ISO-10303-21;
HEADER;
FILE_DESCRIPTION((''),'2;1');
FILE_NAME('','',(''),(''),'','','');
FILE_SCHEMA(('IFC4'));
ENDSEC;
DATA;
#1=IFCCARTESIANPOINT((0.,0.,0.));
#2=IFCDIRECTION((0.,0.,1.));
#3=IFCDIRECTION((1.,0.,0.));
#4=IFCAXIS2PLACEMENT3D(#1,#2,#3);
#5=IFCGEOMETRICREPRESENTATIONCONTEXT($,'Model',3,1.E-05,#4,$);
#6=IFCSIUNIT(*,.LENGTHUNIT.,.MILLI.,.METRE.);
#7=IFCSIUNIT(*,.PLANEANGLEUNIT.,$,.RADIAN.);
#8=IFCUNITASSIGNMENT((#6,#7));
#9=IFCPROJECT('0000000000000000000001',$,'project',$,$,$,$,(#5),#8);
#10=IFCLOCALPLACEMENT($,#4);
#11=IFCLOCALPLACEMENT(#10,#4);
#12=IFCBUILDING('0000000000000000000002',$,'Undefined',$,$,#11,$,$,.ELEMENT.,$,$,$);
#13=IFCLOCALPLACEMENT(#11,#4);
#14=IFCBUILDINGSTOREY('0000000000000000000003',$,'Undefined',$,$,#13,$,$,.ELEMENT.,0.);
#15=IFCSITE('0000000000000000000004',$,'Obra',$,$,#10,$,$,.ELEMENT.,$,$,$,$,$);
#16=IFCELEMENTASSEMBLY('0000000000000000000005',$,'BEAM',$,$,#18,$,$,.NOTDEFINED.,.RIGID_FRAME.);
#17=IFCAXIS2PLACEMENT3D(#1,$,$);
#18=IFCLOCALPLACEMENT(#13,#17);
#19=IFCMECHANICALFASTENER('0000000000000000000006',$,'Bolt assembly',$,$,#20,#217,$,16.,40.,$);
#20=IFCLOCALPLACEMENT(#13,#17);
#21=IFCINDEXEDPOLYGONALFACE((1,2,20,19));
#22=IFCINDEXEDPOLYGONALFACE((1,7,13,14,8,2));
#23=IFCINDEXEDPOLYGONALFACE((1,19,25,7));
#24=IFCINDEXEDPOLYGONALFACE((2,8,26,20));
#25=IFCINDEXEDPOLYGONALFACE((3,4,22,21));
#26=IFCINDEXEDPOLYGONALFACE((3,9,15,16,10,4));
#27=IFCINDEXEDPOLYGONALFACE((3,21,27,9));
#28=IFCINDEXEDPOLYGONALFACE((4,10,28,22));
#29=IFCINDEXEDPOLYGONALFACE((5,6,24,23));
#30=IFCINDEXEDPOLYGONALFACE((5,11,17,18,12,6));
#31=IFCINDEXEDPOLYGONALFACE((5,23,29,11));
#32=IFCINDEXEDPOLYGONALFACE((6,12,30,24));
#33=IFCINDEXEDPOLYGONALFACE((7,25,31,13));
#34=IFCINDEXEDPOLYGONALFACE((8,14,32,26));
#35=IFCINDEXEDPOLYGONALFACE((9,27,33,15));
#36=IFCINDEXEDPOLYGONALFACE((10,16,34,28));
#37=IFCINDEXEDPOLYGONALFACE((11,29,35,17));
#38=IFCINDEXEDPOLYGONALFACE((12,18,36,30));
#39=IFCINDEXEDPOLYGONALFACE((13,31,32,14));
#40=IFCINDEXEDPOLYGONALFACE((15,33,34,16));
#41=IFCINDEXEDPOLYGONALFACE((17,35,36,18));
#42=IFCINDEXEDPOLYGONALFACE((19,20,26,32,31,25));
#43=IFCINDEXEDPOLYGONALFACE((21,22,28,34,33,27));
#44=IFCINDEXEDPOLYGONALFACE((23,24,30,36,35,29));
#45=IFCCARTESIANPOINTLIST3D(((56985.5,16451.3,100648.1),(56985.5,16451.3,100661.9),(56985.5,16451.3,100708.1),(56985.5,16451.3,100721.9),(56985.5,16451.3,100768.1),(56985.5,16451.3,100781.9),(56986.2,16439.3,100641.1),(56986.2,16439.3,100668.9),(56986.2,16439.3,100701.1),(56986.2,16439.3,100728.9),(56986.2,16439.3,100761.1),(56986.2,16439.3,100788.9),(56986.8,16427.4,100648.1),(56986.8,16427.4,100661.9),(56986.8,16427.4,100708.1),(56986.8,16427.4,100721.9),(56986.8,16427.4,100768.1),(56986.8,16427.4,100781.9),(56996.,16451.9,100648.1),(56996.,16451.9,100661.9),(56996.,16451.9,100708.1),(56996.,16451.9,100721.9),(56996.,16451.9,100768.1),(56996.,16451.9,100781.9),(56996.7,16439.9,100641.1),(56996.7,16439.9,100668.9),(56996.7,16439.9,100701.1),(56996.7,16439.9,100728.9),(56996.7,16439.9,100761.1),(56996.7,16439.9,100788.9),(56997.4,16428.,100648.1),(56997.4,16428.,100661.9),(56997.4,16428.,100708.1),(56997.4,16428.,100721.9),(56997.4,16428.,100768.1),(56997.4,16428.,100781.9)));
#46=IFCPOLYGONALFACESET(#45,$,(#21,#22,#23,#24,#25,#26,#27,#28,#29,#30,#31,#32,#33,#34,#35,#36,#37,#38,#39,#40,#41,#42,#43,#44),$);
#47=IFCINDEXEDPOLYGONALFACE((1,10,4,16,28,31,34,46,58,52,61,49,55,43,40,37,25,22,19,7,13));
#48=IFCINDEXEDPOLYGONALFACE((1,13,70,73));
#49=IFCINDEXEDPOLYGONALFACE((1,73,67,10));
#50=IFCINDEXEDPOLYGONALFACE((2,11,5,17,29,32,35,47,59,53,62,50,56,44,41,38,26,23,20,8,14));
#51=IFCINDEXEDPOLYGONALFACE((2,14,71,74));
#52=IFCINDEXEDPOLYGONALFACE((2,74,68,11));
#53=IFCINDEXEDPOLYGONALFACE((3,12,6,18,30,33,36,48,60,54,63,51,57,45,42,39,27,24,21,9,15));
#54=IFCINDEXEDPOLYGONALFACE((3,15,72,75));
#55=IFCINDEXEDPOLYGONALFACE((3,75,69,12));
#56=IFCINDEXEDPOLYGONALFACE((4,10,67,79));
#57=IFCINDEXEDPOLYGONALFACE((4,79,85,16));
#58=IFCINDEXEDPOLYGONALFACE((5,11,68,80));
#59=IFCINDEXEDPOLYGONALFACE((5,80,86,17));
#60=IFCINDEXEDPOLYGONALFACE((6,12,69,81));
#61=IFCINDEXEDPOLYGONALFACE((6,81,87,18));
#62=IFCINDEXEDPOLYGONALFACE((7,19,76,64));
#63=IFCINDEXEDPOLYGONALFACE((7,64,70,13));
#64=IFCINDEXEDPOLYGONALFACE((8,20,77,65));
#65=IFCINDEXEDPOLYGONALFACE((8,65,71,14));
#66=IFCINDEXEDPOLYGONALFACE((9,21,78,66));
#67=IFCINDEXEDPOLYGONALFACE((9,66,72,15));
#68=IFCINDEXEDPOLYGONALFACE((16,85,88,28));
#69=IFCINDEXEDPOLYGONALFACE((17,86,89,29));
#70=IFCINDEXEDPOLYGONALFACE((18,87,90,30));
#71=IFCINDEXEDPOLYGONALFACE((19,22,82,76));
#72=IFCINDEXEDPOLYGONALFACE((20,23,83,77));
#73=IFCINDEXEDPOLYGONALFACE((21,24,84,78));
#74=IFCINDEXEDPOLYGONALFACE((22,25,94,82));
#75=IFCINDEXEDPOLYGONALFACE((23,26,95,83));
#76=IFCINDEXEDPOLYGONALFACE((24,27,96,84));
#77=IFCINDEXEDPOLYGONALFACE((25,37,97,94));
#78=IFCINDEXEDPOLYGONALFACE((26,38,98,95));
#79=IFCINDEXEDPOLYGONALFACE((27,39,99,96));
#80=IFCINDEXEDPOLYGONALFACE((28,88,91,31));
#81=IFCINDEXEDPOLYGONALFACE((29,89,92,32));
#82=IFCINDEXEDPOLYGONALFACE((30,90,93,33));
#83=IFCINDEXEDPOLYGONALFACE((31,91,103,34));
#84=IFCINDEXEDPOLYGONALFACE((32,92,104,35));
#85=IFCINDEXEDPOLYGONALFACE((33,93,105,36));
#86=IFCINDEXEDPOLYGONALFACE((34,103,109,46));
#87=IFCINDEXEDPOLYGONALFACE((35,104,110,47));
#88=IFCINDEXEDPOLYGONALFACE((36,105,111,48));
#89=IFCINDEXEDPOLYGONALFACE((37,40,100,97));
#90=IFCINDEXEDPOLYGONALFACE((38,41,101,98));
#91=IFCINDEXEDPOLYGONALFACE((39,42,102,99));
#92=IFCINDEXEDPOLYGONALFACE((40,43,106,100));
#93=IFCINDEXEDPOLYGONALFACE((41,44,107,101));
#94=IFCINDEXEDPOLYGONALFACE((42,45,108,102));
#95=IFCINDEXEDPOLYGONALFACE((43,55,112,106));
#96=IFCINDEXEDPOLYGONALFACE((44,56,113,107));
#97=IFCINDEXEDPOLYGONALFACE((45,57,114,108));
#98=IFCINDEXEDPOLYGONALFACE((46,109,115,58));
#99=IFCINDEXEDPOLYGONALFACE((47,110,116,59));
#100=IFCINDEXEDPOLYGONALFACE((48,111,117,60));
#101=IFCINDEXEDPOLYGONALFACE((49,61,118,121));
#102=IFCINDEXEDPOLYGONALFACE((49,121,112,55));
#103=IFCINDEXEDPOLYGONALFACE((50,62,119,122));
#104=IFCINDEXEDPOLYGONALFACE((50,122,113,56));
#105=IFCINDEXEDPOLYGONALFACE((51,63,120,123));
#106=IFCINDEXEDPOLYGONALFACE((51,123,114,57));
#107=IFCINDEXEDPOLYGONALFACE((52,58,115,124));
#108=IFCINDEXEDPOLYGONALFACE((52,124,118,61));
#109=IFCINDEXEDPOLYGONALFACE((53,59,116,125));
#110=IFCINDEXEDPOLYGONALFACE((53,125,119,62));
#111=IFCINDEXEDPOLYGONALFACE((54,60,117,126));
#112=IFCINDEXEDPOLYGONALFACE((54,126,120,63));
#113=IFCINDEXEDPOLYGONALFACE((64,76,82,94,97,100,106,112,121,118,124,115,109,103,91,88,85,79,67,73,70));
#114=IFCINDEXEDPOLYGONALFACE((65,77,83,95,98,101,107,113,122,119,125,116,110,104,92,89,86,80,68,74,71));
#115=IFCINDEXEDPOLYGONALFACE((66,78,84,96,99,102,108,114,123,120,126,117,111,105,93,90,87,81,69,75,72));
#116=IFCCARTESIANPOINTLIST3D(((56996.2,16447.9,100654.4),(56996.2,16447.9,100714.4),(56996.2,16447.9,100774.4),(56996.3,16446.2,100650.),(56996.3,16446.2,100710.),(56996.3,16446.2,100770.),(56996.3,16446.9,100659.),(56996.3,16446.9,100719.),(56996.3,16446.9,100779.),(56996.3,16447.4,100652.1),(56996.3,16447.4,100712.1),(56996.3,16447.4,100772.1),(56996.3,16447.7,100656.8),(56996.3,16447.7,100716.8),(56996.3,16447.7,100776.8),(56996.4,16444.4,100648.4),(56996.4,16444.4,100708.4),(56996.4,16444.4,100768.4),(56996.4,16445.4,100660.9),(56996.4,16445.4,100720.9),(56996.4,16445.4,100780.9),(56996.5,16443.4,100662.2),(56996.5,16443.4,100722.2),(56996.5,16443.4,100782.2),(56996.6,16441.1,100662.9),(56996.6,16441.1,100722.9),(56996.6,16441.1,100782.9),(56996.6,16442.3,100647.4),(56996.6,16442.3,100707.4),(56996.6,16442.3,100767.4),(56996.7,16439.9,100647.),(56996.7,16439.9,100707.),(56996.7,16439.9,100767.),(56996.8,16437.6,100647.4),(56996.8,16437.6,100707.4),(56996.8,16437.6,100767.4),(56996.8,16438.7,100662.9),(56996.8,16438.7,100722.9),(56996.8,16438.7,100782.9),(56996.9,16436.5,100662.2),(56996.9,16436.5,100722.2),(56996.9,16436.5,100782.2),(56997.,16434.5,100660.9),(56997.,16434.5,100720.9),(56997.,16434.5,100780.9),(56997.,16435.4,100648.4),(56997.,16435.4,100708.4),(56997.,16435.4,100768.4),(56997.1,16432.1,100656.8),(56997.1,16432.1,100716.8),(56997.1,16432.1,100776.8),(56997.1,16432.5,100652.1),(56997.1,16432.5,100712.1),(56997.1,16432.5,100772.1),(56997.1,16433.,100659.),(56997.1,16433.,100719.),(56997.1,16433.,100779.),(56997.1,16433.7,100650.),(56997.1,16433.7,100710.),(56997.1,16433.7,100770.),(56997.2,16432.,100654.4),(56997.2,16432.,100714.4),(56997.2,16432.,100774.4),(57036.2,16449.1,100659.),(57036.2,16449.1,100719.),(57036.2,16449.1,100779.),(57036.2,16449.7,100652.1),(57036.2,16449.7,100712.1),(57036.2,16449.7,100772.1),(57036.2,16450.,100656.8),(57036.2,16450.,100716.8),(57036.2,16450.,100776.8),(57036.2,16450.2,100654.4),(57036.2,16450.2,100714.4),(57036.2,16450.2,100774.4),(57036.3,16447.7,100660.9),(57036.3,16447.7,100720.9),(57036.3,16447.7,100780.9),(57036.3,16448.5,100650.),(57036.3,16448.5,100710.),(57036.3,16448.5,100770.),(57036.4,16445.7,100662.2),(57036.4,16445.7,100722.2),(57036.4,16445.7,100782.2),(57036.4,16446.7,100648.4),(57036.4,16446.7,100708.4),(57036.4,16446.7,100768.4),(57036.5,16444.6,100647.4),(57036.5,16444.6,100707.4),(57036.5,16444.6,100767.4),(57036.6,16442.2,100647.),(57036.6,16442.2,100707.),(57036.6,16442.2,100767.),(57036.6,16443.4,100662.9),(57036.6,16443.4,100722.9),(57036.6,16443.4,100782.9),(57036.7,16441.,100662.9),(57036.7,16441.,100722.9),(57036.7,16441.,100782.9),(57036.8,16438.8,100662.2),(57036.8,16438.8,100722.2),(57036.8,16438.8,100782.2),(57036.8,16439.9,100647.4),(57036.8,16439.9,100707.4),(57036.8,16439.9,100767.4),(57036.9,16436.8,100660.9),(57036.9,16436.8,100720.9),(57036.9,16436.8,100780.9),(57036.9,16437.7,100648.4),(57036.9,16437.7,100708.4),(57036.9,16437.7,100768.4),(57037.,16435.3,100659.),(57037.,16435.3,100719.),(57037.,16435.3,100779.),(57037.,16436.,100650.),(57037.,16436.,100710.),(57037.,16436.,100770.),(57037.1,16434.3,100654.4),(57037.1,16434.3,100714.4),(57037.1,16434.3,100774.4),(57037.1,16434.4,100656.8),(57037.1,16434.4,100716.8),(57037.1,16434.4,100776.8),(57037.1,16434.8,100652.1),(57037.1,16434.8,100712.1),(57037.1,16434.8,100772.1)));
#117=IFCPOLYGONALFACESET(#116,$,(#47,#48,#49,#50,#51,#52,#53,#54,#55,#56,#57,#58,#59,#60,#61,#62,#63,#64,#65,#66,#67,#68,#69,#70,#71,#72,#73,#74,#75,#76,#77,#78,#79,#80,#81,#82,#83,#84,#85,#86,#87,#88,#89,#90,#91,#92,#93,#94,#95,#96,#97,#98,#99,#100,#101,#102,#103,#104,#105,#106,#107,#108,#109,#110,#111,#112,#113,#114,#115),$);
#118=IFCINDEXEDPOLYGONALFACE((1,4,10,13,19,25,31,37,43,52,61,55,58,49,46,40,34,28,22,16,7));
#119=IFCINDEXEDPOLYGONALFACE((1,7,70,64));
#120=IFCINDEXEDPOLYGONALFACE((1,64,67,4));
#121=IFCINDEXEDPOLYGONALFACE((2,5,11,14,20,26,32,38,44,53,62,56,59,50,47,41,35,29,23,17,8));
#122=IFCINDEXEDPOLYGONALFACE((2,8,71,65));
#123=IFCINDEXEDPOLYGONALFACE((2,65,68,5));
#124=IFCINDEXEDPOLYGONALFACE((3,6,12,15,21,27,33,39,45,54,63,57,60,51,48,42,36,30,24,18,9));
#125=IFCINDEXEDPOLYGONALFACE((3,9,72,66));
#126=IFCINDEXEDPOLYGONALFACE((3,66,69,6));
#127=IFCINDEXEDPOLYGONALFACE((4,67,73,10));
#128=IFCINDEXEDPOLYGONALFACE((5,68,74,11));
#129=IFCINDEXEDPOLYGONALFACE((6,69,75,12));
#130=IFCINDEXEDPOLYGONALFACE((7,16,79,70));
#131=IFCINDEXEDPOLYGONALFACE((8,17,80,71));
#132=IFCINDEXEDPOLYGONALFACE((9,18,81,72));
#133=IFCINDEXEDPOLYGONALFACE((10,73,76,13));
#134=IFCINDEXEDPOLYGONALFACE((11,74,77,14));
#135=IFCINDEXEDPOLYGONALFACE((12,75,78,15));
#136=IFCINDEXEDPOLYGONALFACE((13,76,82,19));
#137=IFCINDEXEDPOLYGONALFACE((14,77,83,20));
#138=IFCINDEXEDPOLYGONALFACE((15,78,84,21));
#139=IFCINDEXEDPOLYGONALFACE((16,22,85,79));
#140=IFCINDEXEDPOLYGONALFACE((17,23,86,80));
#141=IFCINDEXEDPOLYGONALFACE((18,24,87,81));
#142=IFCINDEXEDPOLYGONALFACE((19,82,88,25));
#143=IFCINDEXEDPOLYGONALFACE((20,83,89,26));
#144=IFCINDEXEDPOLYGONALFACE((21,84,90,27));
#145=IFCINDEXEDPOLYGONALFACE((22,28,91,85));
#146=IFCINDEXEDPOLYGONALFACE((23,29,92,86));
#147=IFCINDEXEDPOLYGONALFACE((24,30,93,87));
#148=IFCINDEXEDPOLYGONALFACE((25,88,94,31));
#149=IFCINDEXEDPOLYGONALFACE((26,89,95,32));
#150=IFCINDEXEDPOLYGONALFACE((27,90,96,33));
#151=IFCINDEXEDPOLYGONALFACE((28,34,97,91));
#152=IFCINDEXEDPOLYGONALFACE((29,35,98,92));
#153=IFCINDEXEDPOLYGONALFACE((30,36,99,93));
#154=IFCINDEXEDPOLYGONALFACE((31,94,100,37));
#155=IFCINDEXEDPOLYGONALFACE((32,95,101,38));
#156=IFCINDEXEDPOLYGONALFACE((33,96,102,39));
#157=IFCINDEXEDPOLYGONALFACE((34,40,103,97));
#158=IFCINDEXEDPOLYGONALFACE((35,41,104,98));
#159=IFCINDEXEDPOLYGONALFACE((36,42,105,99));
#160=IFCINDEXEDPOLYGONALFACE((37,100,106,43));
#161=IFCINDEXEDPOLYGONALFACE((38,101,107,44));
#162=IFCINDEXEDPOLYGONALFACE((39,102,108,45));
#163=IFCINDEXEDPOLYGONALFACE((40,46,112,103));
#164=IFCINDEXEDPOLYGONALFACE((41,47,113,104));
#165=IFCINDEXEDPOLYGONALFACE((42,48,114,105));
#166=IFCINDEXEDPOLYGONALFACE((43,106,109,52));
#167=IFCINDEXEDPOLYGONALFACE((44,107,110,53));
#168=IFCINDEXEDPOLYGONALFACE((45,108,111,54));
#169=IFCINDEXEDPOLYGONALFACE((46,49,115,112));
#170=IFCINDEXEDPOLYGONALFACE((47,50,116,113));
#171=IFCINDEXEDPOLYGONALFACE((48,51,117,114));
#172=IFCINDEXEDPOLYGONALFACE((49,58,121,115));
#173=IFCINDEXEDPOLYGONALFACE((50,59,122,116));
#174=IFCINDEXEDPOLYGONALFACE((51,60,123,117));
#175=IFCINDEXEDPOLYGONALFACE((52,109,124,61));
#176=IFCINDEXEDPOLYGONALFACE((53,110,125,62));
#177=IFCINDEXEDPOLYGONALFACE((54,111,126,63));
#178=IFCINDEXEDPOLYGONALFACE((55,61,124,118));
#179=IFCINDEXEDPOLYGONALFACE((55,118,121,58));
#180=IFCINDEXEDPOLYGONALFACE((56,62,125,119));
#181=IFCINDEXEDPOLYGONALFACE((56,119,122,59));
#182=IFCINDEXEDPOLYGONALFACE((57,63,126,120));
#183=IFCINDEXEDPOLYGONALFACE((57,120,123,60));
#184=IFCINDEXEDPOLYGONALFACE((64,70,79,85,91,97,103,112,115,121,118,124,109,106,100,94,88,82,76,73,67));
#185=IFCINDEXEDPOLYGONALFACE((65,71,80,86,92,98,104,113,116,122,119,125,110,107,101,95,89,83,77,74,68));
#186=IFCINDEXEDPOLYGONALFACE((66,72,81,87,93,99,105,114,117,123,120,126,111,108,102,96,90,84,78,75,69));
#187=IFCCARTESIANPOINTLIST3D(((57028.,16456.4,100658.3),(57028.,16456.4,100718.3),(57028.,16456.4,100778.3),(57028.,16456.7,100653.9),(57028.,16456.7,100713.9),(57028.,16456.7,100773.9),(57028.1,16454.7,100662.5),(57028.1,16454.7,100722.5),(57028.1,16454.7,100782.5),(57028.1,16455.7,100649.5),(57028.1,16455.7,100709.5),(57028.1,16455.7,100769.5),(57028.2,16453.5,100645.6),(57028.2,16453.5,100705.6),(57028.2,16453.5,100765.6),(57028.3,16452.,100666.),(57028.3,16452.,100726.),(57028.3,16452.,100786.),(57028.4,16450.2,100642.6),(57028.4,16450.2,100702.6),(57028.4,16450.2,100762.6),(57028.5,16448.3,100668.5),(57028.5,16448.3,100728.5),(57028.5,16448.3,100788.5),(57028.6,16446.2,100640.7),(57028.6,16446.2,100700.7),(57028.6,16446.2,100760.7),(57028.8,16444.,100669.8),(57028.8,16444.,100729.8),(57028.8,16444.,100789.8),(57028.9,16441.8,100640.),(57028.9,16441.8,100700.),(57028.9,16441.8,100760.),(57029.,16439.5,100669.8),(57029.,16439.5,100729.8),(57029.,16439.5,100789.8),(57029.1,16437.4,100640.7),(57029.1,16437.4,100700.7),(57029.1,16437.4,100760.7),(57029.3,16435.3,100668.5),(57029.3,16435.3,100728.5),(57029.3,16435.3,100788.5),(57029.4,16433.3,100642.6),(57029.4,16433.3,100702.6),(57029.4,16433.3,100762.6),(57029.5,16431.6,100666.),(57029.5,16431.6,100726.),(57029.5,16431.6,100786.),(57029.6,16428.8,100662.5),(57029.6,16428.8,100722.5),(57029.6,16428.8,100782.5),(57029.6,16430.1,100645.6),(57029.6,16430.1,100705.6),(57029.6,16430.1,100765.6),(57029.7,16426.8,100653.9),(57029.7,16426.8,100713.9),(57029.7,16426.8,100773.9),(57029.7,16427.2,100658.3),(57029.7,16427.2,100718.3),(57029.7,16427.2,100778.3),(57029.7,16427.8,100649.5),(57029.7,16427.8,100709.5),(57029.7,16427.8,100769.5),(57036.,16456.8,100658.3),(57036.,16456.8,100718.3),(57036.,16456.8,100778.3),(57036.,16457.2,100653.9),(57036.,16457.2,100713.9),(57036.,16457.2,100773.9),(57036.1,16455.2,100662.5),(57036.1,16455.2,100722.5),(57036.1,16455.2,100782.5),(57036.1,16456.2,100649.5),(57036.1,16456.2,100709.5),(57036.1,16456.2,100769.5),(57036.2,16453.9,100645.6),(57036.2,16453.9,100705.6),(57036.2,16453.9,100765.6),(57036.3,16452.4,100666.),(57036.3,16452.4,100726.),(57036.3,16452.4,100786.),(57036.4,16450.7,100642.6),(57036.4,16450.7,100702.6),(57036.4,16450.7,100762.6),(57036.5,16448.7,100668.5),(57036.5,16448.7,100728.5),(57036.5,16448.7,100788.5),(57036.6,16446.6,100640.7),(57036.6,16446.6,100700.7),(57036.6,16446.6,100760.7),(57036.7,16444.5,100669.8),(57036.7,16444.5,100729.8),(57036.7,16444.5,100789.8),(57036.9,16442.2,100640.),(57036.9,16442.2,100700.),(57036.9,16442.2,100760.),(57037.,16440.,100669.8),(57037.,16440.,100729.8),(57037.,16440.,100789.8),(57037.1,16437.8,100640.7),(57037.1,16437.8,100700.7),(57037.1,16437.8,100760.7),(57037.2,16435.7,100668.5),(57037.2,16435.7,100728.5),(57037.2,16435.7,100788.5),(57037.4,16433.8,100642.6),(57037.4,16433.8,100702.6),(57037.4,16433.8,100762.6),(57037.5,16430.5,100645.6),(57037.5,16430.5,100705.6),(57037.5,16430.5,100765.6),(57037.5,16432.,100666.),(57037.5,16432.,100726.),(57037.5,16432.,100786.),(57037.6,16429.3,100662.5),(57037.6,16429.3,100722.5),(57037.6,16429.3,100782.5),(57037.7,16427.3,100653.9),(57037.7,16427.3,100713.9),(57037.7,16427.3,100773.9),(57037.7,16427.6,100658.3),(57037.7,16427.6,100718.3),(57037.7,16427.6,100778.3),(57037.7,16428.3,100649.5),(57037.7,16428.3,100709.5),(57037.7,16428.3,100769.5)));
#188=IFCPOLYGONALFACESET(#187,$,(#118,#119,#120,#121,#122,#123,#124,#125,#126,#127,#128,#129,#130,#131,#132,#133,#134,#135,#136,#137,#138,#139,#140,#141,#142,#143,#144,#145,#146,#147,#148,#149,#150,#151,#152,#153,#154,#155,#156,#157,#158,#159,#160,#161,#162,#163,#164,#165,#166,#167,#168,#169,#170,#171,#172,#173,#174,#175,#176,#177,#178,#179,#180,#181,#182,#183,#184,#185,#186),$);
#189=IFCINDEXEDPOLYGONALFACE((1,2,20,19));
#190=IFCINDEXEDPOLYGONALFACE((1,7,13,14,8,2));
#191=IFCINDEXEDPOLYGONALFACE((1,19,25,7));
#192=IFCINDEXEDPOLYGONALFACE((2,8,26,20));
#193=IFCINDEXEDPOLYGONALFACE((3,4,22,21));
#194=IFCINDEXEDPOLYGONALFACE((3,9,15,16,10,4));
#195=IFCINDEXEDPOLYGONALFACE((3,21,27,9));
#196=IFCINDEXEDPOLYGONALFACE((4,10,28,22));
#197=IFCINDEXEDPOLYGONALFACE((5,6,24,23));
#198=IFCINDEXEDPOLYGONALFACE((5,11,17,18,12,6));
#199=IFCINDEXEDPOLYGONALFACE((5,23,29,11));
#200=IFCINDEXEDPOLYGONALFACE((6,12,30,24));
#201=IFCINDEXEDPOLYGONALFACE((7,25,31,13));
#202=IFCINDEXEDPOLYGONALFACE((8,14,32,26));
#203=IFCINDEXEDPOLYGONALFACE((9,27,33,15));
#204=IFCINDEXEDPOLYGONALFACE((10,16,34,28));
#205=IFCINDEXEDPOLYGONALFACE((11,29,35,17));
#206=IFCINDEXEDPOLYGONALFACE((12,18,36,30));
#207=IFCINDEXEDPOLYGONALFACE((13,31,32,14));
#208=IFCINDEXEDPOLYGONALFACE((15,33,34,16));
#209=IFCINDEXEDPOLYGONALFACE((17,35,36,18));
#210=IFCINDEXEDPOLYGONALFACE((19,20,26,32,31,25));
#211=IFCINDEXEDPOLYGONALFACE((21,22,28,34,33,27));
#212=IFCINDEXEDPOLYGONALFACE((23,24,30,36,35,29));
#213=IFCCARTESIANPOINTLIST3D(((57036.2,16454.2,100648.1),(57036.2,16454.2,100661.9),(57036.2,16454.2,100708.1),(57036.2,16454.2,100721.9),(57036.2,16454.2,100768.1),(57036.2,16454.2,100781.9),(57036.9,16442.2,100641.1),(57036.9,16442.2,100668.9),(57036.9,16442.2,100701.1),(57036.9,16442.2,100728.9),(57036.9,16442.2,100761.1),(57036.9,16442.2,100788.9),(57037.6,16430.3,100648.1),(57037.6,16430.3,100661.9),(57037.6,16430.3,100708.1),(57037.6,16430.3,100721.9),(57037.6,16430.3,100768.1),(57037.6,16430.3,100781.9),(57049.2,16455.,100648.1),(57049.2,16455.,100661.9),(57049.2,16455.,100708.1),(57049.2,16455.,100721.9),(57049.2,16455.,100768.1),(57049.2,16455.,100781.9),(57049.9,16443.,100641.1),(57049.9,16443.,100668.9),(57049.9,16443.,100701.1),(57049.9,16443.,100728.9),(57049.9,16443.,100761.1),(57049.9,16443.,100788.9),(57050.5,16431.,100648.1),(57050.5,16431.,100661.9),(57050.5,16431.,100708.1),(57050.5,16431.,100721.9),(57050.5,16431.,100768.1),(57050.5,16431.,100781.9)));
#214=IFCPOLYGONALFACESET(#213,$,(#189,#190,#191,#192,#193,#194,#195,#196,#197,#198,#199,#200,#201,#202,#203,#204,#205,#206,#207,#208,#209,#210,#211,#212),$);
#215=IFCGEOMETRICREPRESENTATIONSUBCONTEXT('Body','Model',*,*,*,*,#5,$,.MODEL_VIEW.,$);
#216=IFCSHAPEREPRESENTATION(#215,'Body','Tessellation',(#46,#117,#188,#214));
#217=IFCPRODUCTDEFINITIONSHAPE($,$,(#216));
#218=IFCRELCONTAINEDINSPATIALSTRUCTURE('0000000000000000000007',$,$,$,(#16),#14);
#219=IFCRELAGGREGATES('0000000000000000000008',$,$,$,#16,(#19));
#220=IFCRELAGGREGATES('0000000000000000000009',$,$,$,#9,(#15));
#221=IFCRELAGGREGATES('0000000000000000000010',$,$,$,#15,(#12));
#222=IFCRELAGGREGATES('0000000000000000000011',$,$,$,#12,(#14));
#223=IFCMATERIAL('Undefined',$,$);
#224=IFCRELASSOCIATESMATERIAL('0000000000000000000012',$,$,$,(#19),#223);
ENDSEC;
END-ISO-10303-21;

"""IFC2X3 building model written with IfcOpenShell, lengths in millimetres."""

from ifc_helpers import new_model, si_unit, frame, origin_with_axes, origin_2d_with_axis, place, context, subcontext, project, spatial, polyline, circle, outline, extrude, source, transform, mapped, material, element, aggregate, save


model = new_model("IFC2X3")

# Units and contexts
model_context = context("Model", 3, precision=1e-05, world=origin_with_axes())
body_context = subcontext(model_context, "Body", "Model", "MODEL_VIEW")
ifc_project = project(units=[si_unit("LENGTHUNIT", "METRE", prefix="MILLI"), si_unit("PLANEANGLEUNIT", "RADIAN")], contexts=[model_context])

# Site, building, storey
site_placement = place(None, origin_with_axes())
site = spatial("IfcSite", under=ifc_project, at=site_placement, Name="Obra", CompositionType="ELEMENT")
building_placement = place(site_placement, origin_with_axes())
building = spatial("IfcBuilding", under=site, at=building_placement, Name="Undefined", CompositionType="ELEMENT")
storey_placement = place(building_placement, origin_with_axes())
storey = spatial("IfcBuildingStorey", under=building, at=storey_placement, Name="Undefined", CompositionType="ELEMENT", Elevation=0.0)

# Shared definitions
ifc_material_1 = material(Name="Undefined")

# Element assembly
assembly_1_placement = place(storey_placement, origin_with_axes())
assembly_1 = element("IfcElementAssembly", 1, at=assembly_1_placement, inside=storey, Name="BEAM", AssemblyPlace="NOTDEFINED", PredefinedType="RIGID_FRAME")

# Mechanical fastener
shared_shape_1 = source(origin_with_axes(), body_context, "Body", "SweptSolid", [
    extrude(outline(polyline([(13.9, 0.0), (6.9, 12.0), (-6.9, 12.0), (-13.9, 0.0), (-6.9, -12.0), (6.9, -12.0), (13.9, 0.0)])), frame((0.0, -45.9, 0.0), z_axis=(0.0, 1.0, 0.0), x_axis=(1.0, 0.0, 0.0)), (0.0, 0.0, 1.0), 10.6),
    extrude(circle(Radius=8.0, at=origin_2d_with_axis()), frame((0.0, -35.3, 0.0), z_axis=(0.0, 1.0, 0.0), x_axis=(1.0, 0.0, 0.0)), (0.0, 0.0, 1.0), 40.0),
    extrude(circle(Radius=15.0, at=origin_2d_with_axis()), frame((0.0, -3.1, 0.0), z_axis=(0.0, 1.0, 0.0), x_axis=(1.0, 0.0, 0.0)), (0.0, 0.0, 1.0), 8.0),
    extrude(outline(polyline([(13.9, 0.0), (6.9, 12.0), (-6.9, 12.0), (-13.9, 0.0), (-6.9, -12.0), (6.9, -12.0), (13.9, 0.0)])), frame((0.0, 4.9, 0.0), z_axis=(0.0, 1.0, 0.0), x_axis=(1.0, 0.0, 0.0)), (0.0, 0.0, 1.0), 13.0),
])
mechanical_fastener_1_placement = place(assembly_1_placement, frame((57029.1, 16491.9, 100835.0), z_axis=(0.057107, -0.998368, 0.0), x_axis=(0.0, 0.0, -1.0)))
mechanical_fastener_1 = element("IfcMechanicalFastener", 2, at=mechanical_fastener_1_placement, material=ifc_material_1, Name="Bolt assembly", NominalDiameter=16.0, NominalLength=40.0, context=body_context, shape_type="MappedRepresentation", body=[
    mapped(shared_shape_1, transform((60.0, 0.0, 50.0))),
    mapped(shared_shape_1, transform((120.0, 0.0, 50.0))),
    mapped(shared_shape_1, transform((180.0, 0.0, 50.0))),
])
aggregate(assembly_1, [mechanical_fastener_1])

save(model, "model.ifc")
